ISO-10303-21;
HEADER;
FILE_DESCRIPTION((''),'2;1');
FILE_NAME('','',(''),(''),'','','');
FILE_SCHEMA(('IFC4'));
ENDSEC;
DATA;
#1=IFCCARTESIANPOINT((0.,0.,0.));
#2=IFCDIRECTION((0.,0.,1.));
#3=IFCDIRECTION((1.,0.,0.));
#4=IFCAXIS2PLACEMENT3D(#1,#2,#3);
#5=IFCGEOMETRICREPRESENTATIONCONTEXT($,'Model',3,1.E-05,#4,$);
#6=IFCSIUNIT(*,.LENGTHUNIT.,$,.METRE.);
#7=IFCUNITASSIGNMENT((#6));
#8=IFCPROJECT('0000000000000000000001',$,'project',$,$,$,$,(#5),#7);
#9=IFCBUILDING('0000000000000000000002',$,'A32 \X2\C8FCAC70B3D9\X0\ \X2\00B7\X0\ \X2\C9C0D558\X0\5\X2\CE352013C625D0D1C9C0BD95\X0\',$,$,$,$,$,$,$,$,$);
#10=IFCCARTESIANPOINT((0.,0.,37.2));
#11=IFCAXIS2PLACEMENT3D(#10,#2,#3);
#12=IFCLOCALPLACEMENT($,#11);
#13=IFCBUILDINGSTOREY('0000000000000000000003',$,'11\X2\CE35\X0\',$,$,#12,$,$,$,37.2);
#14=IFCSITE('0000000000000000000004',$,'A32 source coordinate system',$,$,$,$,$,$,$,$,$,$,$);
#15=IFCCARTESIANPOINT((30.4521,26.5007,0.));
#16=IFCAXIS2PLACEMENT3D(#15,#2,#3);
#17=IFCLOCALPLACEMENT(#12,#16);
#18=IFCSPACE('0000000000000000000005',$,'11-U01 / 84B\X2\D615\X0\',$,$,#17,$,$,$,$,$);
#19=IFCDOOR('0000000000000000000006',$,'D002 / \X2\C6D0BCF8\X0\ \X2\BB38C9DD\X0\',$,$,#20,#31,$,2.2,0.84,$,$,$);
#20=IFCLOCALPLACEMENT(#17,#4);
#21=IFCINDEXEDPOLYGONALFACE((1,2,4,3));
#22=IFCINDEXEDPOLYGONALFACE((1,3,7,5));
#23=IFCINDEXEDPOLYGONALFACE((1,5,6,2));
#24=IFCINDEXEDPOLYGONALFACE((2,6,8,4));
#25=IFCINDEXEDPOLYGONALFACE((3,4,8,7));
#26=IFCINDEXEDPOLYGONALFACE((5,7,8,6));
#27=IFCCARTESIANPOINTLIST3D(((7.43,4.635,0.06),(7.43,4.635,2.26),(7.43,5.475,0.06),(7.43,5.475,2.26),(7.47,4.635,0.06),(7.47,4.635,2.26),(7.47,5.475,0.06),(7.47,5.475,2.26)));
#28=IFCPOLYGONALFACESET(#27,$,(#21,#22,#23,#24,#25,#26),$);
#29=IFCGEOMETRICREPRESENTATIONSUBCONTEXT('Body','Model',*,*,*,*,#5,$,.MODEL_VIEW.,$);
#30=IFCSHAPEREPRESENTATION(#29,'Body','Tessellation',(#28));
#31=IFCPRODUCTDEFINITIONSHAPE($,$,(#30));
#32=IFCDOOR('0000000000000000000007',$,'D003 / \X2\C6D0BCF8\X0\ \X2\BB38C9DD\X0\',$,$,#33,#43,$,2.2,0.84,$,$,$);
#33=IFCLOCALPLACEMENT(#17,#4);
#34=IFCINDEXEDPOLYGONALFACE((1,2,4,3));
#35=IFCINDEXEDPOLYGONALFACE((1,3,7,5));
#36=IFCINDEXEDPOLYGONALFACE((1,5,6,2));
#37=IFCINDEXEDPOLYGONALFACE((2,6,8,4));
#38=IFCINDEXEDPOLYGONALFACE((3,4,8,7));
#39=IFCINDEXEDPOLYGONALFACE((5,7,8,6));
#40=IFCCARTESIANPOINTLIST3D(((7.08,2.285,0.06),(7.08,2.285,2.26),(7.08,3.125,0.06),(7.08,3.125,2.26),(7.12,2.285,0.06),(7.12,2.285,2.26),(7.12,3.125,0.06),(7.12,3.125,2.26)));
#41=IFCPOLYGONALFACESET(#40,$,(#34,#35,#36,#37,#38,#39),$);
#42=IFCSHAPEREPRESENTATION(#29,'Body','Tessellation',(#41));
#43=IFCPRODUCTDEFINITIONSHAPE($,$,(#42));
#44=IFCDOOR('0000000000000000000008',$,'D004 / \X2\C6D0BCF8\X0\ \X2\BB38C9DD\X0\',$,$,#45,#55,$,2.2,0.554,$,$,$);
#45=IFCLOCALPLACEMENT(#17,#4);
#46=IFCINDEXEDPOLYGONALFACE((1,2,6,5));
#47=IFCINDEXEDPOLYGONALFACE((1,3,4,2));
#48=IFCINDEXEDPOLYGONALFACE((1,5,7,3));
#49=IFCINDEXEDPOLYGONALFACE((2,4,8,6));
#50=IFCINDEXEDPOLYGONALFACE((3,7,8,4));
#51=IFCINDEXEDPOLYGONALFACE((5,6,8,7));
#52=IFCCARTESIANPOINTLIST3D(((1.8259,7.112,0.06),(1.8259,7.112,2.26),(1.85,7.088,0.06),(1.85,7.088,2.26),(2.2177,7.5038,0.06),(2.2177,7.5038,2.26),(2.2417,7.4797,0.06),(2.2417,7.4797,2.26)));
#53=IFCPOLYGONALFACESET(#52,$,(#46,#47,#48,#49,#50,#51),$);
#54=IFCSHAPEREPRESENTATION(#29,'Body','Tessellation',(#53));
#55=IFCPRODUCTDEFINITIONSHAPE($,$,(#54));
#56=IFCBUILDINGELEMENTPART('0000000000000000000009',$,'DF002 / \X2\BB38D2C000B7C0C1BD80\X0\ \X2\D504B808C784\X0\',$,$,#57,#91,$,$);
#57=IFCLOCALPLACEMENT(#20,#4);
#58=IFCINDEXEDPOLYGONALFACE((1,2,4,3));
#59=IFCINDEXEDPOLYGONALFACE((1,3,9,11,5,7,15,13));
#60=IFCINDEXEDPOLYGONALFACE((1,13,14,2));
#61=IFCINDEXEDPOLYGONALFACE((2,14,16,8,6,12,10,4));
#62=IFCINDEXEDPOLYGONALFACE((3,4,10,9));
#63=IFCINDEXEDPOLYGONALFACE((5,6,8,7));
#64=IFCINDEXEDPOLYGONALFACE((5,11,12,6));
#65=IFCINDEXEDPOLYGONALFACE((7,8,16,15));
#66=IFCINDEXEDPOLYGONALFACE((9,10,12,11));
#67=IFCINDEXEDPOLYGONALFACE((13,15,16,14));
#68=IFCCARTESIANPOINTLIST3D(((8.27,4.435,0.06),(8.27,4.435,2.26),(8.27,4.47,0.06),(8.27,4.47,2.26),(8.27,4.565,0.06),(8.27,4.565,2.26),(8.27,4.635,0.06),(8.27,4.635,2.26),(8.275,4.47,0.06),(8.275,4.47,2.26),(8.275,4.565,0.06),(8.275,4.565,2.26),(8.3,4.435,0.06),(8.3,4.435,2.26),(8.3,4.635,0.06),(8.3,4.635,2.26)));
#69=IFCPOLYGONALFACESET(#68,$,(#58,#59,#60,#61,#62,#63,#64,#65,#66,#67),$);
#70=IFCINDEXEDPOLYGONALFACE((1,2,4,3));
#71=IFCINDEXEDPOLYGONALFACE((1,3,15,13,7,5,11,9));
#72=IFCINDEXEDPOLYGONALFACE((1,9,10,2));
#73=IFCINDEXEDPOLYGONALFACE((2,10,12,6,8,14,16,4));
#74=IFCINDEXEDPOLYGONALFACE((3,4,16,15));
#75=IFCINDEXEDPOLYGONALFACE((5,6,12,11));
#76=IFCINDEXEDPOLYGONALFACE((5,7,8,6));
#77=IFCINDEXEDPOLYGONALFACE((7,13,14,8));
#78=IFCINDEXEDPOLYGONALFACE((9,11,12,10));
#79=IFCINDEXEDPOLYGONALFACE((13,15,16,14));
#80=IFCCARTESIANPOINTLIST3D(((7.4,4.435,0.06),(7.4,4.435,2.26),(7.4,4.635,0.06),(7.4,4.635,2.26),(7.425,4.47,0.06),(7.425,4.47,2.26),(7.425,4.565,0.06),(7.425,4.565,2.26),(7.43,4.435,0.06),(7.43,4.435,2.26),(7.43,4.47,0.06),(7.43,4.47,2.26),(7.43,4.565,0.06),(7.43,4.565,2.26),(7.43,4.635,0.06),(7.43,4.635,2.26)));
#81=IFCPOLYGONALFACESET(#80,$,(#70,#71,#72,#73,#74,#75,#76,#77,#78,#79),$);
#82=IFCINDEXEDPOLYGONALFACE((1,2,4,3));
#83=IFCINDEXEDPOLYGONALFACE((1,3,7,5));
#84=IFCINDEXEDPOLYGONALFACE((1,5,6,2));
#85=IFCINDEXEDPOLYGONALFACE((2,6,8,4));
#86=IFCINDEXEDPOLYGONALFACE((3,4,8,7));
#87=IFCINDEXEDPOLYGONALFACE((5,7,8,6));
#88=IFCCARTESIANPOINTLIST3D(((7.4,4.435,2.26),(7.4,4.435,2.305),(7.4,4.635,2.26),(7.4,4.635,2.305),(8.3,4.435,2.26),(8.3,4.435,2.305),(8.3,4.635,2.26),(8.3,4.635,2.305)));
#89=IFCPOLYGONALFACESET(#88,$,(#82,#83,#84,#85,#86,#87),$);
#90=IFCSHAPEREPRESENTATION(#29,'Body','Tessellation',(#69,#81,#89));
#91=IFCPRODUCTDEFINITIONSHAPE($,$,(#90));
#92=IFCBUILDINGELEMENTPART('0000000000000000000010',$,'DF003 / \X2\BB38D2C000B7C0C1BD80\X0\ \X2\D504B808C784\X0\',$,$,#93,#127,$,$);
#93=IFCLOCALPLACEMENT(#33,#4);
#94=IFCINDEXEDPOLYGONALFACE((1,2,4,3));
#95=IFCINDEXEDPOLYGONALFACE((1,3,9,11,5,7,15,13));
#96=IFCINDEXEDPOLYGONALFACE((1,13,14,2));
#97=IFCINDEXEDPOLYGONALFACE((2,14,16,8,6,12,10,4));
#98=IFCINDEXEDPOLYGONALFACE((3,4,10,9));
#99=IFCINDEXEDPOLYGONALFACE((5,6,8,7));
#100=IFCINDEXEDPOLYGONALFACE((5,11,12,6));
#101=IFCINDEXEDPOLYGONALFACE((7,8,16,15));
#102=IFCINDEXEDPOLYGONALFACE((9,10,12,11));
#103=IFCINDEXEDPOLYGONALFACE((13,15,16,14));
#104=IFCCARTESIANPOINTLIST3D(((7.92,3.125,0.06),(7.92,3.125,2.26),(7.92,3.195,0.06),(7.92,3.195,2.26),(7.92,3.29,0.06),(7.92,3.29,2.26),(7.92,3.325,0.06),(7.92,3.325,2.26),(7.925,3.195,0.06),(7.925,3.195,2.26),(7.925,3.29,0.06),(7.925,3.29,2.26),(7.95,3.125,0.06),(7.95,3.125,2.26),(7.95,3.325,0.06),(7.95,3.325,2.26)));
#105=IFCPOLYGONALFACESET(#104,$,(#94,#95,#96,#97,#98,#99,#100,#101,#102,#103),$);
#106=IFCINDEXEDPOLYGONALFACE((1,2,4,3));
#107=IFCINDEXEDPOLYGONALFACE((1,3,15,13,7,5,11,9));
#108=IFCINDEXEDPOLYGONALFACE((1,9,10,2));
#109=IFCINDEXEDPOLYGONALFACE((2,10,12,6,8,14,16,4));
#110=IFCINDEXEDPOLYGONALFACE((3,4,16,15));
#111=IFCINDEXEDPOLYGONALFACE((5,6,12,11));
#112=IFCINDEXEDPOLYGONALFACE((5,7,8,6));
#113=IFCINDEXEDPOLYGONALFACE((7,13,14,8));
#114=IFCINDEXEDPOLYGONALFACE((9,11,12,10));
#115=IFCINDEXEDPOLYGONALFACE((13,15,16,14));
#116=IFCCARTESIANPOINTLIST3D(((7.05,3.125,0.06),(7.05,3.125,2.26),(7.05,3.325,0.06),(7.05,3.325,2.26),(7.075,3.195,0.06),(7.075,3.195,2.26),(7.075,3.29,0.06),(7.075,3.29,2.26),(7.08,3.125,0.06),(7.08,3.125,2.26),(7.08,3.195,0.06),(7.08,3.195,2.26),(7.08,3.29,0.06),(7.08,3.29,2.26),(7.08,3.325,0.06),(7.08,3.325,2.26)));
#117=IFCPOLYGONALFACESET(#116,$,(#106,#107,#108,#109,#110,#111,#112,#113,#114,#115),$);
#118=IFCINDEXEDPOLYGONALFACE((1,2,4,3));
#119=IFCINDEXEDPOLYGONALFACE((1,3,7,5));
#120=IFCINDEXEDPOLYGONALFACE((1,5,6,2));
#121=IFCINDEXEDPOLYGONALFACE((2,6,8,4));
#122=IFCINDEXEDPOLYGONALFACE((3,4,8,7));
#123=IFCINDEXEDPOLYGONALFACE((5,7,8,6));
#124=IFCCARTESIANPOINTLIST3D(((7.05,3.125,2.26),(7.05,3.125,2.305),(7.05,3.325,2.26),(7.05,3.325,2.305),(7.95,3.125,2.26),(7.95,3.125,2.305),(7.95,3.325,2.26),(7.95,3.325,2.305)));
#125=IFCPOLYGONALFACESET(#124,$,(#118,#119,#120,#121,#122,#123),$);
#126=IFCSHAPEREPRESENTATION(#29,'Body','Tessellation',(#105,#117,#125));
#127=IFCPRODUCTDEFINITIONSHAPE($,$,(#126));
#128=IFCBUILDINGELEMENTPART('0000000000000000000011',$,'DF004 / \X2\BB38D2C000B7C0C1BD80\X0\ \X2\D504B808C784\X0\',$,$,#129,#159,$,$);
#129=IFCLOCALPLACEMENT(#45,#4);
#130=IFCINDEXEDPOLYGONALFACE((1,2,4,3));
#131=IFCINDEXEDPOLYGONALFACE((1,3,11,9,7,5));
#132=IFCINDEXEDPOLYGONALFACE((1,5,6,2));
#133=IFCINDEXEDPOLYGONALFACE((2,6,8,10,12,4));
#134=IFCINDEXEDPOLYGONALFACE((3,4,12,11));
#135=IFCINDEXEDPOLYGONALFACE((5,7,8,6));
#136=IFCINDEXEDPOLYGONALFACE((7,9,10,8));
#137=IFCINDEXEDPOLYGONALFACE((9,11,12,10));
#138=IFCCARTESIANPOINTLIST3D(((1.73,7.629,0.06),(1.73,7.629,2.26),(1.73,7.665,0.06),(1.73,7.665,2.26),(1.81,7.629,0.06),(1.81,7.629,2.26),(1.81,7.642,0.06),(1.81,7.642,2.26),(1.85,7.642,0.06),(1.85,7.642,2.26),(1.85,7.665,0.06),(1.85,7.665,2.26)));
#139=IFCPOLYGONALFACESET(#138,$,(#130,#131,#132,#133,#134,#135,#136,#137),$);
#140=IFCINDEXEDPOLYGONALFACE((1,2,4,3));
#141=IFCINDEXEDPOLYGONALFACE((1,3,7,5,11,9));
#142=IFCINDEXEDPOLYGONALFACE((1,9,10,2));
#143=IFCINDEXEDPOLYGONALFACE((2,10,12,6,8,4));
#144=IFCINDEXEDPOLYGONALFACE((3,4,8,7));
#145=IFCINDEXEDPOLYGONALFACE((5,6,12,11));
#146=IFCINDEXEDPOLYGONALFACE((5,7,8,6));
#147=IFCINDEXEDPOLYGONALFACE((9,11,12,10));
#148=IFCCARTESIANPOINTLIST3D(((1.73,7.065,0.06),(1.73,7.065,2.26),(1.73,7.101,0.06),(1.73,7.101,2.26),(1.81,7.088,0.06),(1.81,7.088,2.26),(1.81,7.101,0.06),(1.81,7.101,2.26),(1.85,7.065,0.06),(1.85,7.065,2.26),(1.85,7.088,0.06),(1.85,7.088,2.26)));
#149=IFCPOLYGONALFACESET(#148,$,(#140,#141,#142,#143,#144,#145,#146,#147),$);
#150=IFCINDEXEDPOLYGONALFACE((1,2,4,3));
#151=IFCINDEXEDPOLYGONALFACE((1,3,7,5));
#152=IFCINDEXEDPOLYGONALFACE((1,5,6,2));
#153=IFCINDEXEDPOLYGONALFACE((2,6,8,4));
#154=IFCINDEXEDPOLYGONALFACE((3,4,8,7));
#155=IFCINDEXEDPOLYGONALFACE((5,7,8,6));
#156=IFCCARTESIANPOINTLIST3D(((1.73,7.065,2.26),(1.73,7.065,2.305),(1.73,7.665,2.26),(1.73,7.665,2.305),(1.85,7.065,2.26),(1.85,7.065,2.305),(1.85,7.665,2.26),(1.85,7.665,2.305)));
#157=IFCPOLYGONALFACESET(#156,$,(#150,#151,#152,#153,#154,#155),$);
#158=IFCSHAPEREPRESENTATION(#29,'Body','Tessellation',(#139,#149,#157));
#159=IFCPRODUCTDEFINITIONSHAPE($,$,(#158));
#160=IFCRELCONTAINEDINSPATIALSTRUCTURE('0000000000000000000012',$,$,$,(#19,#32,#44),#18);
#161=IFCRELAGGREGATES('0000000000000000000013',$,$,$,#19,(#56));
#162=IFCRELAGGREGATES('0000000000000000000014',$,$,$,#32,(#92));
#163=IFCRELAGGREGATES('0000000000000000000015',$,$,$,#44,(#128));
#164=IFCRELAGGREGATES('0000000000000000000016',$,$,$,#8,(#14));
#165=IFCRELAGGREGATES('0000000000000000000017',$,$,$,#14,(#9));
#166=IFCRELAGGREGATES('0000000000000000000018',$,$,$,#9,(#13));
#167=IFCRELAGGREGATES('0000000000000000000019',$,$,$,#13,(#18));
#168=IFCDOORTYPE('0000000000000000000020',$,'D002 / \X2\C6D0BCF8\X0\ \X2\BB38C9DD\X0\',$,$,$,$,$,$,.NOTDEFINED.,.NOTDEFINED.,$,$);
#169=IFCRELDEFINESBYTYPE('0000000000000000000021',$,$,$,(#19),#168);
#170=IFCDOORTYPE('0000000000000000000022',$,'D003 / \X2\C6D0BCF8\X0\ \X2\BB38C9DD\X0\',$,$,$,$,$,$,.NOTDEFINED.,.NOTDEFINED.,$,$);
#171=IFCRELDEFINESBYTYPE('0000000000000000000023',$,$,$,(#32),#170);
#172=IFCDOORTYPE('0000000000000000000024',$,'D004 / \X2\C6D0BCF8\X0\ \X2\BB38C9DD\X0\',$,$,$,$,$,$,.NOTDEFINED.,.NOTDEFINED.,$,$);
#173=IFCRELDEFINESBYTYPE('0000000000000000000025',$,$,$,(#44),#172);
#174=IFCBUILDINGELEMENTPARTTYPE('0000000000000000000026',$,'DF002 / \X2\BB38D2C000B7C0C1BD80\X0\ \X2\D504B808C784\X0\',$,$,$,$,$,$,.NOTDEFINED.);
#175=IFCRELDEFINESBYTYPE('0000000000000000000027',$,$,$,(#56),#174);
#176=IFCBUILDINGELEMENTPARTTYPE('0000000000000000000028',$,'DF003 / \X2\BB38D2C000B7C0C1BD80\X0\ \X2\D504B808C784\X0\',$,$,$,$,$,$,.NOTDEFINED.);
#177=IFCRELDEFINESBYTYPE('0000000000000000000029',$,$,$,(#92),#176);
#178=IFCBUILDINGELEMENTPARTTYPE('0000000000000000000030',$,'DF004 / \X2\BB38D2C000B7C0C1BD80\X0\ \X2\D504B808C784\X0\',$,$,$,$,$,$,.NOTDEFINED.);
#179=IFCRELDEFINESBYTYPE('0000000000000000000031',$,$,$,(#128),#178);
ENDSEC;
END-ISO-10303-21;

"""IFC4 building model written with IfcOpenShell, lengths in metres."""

from ifc_helpers import new_model, si_unit, frame, origin, origin_with_axes, place, context, subcontext, project, spatial, polyline, outline, extrude, source, transform, mapped, type_object, type_shapes, element, aggregate, save


model = new_model("IFC4")

# Units and contexts
model_context = context("Model", 3, precision=1e-05, world=origin_with_axes())
body_context = subcontext(model_context, "Body", "Model", "MODEL_VIEW")
ifc_project = project(units=[si_unit("LENGTHUNIT", "METRE")], contexts=[model_context])

# Site, building, storey, space
storey_placement = place(None, frame((0.0, 0.0, 37.2), z_axis=(0.0, 0.0, 1.0), x_axis=(1.0, 0.0, 0.0)))
space_placement = place(storey_placement, frame((30.4521, 26.5007, 0.0), z_axis=(0.0, 0.0, 1.0), x_axis=(1.0, 0.0, 0.0)))
site = spatial("IfcSite", under=ifc_project, Name="A32 source coordinate system")
building = spatial("IfcBuilding", under=site, Name="A32 주거동 · 지하5층–옥탑지붕")
storey = spatial("IfcBuildingStorey", under=building, at=storey_placement, Name="11층", Elevation=37.2)
space = spatial("IfcSpace", under=storey, at=space_placement, Name="11-U01 / 84B형")

# Doors
door_type_1 = type_object("IfcDoorType", Name="D002 / 원본 문짝", OperationType="NOTDEFINED", PredefinedType="NOTDEFINED")
shared_shape_1 = source(origin(), body_context, "Body", "SweptSolid", [
    extrude(outline(polyline([(7.43, 4.635), (7.43, 5.475), (7.47, 5.475), (7.47, 4.635), (7.43, 4.635)])), frame((0.0, 0.0, 0.06)), (0.0, 0.0, 1.0), 2.2),
])
type_shapes(door_type_1, [shared_shape_1])
door_1_placement = place(space_placement, origin_with_axes())
door_1 = element("IfcDoor", 1, at=door_1_placement, inside=space, type_object=door_type_1, Name="D002 / 원본 문짝", OverallHeight=2.2, OverallWidth=0.84, context=body_context, shape_type="MappedRepresentation", body=[
    mapped(shared_shape_1, transform((0.0, 0.0, 0.0), scale=1.0)),
])
door_type_2 = type_object("IfcDoorType", Name="D003 / 원본 문짝", OperationType="NOTDEFINED", PredefinedType="NOTDEFINED")
shared_shape_2 = source(origin(), body_context, "Body", "SweptSolid", [
    extrude(outline(polyline([(7.12, 2.285), (7.08, 2.285), (7.08, 3.125), (7.12, 3.125), (7.12, 2.285)])), frame((0.0, 0.0, 0.06)), (0.0, 0.0, 1.0), 2.2),
])
type_shapes(door_type_2, [shared_shape_2])
door_2_placement = place(space_placement, origin_with_axes())
door_2 = element("IfcDoor", 2, at=door_2_placement, inside=space, type_object=door_type_2, Name="D003 / 원본 문짝", OverallHeight=2.2, OverallWidth=0.84, context=body_context, shape_type="MappedRepresentation", body=[
    mapped(shared_shape_2, transform((0.0, 0.0, 0.0), scale=1.0)),
])
door_type_3 = type_object("IfcDoorType", Name="D004 / 원본 문짝", OperationType="NOTDEFINED", PredefinedType="NOTDEFINED")
shared_shape_3 = source(origin(), body_context, "Body", "SweptSolid", [
    extrude(outline(polyline([(2.2177, 7.5038), (2.2417, 7.4797), (1.85, 7.088), (1.8259, 7.112), (2.2177, 7.5038)])), frame((0.0, 0.0, 0.06)), (0.0, 0.0, 1.0), 2.2),
])
type_shapes(door_type_3, [shared_shape_3])
door_3_placement = place(space_placement, origin_with_axes())
door_3 = element("IfcDoor", 3, at=door_3_placement, inside=space, type_object=door_type_3, Name="D004 / 원본 문짝", OverallHeight=2.2, OverallWidth=0.554, context=body_context, shape_type="MappedRepresentation", body=[
    mapped(shared_shape_3, transform((0.0, 0.0, 0.0), scale=1.0)),
])

# Building element parts
building_element_part_type_1 = type_object("IfcBuildingElementPartType", Name="DF002 / 문틀·상부 프레임", PredefinedType="NOTDEFINED")
shared_shape_4 = source(origin(), body_context, "Body", "SweptSolid", [
    extrude(outline(polyline([(8.3, 4.435), (8.27, 4.435), (8.27, 4.47), (8.275, 4.47), (8.275, 4.565), (8.27, 4.565), (8.27, 4.635), (8.3, 4.635), (8.3, 4.435)])), frame((0.0, 0.0, 0.06)), (0.0, 0.0, 1.0), 2.2),
    extrude(outline(polyline([(7.43, 4.635), (7.43, 4.565), (7.425, 4.565), (7.425, 4.47), (7.43, 4.47), (7.43, 4.435), (7.4, 4.435), (7.4, 4.635), (7.43, 4.635)])), frame((0.0, 0.0, 0.06)), (0.0, 0.0, 1.0), 2.2),
    extrude(outline(polyline([(7.4, 4.435), (7.4, 4.635), (8.3, 4.635), (8.3, 4.435), (7.4, 4.435)])), frame((0.0, 0.0, 2.26)), (0.0, 0.0, 1.0), 0.045),
])
type_shapes(building_element_part_type_1, [shared_shape_4])
building_element_part_1_placement = place(door_1_placement, origin_with_axes())
building_element_part_1 = element("IfcBuildingElementPart", 4, at=building_element_part_1_placement, type_object=building_element_part_type_1, Name="DF002 / 문틀·상부 프레임", context=body_context, shape_type="MappedRepresentation", body=[
    mapped(shared_shape_4, transform((0.0, 0.0, 0.0), scale=1.0)),
])
aggregate(door_1, [building_element_part_1])
building_element_part_type_2 = type_object("IfcBuildingElementPartType", Name="DF003 / 문틀·상부 프레임", PredefinedType="NOTDEFINED")
shared_shape_5 = source(origin(), body_context, "Body", "SweptSolid", [
    extrude(outline(polyline([(7.92, 3.125), (7.92, 3.195), (7.925, 3.195), (7.925, 3.29), (7.92, 3.29), (7.92, 3.325), (7.95, 3.325), (7.95, 3.125), (7.92, 3.125)])), frame((0.0, 0.0, 0.06)), (0.0, 0.0, 1.0), 2.2),
    extrude(outline(polyline([(7.05, 3.325), (7.08, 3.325), (7.08, 3.29), (7.075, 3.29), (7.075, 3.195), (7.08, 3.195), (7.08, 3.125), (7.05, 3.125), (7.05, 3.325)])), frame((0.0, 0.0, 0.06)), (0.0, 0.0, 1.0), 2.2),
    extrude(outline(polyline([(7.05, 3.125), (7.05, 3.325), (7.95, 3.325), (7.95, 3.125), (7.05, 3.125)])), frame((0.0, 0.0, 2.26)), (0.0, 0.0, 1.0), 0.045),
])
type_shapes(building_element_part_type_2, [shared_shape_5])
building_element_part_2_placement = place(door_2_placement, origin_with_axes())
building_element_part_2 = element("IfcBuildingElementPart", 5, at=building_element_part_2_placement, type_object=building_element_part_type_2, Name="DF003 / 문틀·상부 프레임", context=body_context, shape_type="MappedRepresentation", body=[
    mapped(shared_shape_5, transform((0.0, 0.0, 0.0), scale=1.0)),
])
aggregate(door_2, [building_element_part_2])
building_element_part_type_3 = type_object("IfcBuildingElementPartType", Name="DF004 / 문틀·상부 프레임", PredefinedType="NOTDEFINED")
shared_shape_6 = source(origin(), body_context, "Body", "SweptSolid", [
    extrude(outline(polyline([(1.85, 7.665), (1.85, 7.642), (1.81, 7.642), (1.81, 7.629), (1.73, 7.629), (1.73, 7.665), (1.85, 7.665)])), frame((0.0, 0.0, 0.06)), (0.0, 0.0, 1.0), 2.2),
    extrude(outline(polyline([(1.73, 7.101), (1.81, 7.101), (1.81, 7.088), (1.85, 7.088), (1.85, 7.065), (1.73, 7.065), (1.73, 7.101)])), frame((0.0, 0.0, 0.06)), (0.0, 0.0, 1.0), 2.2),
    extrude(outline(polyline([(1.73, 7.065), (1.73, 7.665), (1.85, 7.665), (1.85, 7.065), (1.73, 7.065)])), frame((0.0, 0.0, 2.26)), (0.0, 0.0, 1.0), 0.045),
])
type_shapes(building_element_part_type_3, [shared_shape_6])
building_element_part_3_placement = place(door_3_placement, origin_with_axes())
building_element_part_3 = element("IfcBuildingElementPart", 6, at=building_element_part_3_placement, type_object=building_element_part_type_3, Name="DF004 / 문틀·상부 프레임", context=body_context, shape_type="MappedRepresentation", body=[
    mapped(shared_shape_6, transform((0.0, 0.0, 0.0), scale=1.0)),
])
aggregate(door_3, [building_element_part_3])

save(model, "model.ifc")
